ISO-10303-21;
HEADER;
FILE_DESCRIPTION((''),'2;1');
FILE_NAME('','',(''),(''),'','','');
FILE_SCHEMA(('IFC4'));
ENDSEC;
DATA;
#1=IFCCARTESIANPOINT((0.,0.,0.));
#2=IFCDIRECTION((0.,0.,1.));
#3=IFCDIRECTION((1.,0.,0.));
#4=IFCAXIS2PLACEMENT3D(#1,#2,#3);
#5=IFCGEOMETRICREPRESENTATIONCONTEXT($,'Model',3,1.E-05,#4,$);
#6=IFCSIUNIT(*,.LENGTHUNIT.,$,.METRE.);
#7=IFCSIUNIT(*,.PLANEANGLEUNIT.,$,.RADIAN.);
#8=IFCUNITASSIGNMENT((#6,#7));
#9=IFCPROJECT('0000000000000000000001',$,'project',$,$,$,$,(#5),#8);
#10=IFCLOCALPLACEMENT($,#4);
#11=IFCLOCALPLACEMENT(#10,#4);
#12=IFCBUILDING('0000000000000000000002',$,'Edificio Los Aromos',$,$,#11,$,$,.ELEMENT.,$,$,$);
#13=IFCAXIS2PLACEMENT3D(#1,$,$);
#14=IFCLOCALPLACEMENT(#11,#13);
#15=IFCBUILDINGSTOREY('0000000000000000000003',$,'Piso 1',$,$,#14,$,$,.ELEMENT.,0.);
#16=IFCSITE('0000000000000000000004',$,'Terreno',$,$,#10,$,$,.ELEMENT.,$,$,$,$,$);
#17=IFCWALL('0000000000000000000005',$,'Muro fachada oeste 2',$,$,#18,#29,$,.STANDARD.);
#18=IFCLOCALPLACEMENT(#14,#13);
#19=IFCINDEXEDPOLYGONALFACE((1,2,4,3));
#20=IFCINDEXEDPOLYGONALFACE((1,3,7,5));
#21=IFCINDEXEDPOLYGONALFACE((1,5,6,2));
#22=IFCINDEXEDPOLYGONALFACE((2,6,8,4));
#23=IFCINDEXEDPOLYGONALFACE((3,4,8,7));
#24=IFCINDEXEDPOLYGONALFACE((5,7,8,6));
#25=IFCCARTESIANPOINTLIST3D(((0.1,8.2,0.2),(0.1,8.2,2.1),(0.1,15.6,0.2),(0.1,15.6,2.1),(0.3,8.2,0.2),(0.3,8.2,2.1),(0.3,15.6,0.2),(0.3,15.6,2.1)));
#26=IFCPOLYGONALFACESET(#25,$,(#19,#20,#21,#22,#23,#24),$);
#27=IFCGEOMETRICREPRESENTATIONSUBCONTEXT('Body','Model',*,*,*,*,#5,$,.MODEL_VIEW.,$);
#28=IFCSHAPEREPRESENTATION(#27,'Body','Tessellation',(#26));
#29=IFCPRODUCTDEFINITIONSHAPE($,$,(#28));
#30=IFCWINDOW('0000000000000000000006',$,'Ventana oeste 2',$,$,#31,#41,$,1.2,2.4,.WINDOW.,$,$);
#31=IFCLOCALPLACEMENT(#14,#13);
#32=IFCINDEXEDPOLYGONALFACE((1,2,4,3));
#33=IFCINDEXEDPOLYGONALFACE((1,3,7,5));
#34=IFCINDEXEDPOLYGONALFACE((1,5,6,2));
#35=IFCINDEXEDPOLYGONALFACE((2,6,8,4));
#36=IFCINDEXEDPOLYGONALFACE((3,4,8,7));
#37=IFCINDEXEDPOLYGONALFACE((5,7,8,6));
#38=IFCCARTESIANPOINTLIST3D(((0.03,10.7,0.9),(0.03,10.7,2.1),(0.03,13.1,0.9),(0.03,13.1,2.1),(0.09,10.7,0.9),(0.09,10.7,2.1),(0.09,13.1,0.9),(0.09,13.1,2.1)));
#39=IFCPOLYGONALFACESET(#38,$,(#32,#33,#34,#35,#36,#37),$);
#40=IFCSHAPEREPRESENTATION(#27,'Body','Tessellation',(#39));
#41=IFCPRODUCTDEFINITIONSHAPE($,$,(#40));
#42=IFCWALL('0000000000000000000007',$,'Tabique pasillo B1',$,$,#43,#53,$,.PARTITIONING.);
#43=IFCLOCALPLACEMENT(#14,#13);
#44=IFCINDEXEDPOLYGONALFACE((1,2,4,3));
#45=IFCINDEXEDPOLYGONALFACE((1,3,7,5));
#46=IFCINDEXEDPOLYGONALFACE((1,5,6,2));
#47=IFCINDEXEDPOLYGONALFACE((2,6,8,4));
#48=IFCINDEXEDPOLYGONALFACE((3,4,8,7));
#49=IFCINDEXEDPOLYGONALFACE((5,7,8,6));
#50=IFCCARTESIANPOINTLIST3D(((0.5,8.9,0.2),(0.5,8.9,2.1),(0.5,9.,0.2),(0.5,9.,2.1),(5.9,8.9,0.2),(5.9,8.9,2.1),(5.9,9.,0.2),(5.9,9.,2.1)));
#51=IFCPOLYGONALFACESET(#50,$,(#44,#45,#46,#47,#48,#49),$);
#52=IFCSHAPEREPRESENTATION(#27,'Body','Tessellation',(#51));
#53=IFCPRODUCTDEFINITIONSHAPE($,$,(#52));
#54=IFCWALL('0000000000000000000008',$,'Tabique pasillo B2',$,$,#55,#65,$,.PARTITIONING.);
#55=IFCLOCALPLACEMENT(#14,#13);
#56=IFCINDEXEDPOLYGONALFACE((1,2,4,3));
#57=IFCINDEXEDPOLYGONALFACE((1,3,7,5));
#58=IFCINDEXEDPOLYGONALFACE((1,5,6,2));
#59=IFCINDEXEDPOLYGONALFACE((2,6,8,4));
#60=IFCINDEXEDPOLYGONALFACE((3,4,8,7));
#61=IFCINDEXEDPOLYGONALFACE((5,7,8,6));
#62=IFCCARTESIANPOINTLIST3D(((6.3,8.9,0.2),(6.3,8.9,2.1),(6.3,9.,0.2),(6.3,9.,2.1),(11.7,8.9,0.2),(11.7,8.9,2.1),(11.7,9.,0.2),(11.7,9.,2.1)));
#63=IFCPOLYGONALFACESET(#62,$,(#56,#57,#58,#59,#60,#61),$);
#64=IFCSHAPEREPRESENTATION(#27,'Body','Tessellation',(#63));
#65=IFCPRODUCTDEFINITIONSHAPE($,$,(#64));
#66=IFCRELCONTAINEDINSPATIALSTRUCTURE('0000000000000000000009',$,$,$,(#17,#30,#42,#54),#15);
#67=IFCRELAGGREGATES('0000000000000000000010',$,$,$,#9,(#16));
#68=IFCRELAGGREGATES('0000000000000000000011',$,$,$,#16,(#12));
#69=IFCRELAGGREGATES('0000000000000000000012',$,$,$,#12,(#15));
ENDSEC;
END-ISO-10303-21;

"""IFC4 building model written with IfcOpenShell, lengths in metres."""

from ifc_helpers import new_model, si_unit, frame, frame_2d, origin, origin_with_axes, place, context, subcontext, project, spatial, rectangle, extrude, element, save


model = new_model("IFC4")

# Units and contexts
model_context = context("Model", 3, precision=1e-05, world=origin_with_axes())
body_context = subcontext(model_context, "Body", "Model", "MODEL_VIEW")
ifc_project = project(units=[si_unit("LENGTHUNIT", "METRE"), si_unit("PLANEANGLEUNIT", "RADIAN")], contexts=[model_context])

# Site, building, storey
site_placement = place(None, origin_with_axes())
site = spatial("IfcSite", under=ifc_project, at=site_placement, Name="Terreno", CompositionType="ELEMENT")
building_placement = place(site_placement, origin_with_axes())
building = spatial("IfcBuilding", under=site, at=building_placement, Name="Edificio Los Aromos", CompositionType="ELEMENT")
storey_placement = place(building_placement, origin())
storey = spatial("IfcBuildingStorey", under=building, at=storey_placement, Name="Piso 1", CompositionType="ELEMENT", Elevation=0.0)

# Wall
wall_1_placement = place(storey_placement, frame((0.1, 8.2, 0.2)))
element("IfcWall", 1, at=wall_1_placement, inside=storey, Name="Muro fachada oeste 2", PredefinedType="STANDARD", context=body_context, shape_type="SweptSolid", body=[
    extrude(rectangle(XDim=0.2, YDim=7.4, at=frame_2d((0.1, 3.7))), origin_with_axes(), (0.0, 0.0, 1.0), 1.9),
])

# Window
window_1_placement = place(storey_placement, frame((0.03, 10.7, 0.9)))
element("IfcWindow", 2, at=window_1_placement, inside=storey, Name="Ventana oeste 2", OverallHeight=1.2, OverallWidth=2.4, PredefinedType="WINDOW", context=body_context, shape_type="SweptSolid", body=[
    extrude(rectangle(XDim=0.06, YDim=2.4, at=frame_2d((0.03, 1.2))), origin_with_axes(), (0.0, 0.0, 1.0), 1.2),
])

# Walls
for number, where, name in (
    (3, (0.5, 8.9, 0.2), "Tabique pasillo B1"),
    (4, (6.3, 8.9, 0.2), "Tabique pasillo B2"),
):
    element("IfcWall", number, at=place(storey_placement, frame(where)), inside=storey, Name=name, PredefinedType="PARTITIONING", context=body_context, shape_type="SweptSolid", body=[
        extrude(rectangle(XDim=5.4, YDim=0.1, at=frame_2d((2.7, 0.05))), origin_with_axes(), (0.0, 0.0, 1.0), 1.9),
    ])

save(model, "model.ifc")
